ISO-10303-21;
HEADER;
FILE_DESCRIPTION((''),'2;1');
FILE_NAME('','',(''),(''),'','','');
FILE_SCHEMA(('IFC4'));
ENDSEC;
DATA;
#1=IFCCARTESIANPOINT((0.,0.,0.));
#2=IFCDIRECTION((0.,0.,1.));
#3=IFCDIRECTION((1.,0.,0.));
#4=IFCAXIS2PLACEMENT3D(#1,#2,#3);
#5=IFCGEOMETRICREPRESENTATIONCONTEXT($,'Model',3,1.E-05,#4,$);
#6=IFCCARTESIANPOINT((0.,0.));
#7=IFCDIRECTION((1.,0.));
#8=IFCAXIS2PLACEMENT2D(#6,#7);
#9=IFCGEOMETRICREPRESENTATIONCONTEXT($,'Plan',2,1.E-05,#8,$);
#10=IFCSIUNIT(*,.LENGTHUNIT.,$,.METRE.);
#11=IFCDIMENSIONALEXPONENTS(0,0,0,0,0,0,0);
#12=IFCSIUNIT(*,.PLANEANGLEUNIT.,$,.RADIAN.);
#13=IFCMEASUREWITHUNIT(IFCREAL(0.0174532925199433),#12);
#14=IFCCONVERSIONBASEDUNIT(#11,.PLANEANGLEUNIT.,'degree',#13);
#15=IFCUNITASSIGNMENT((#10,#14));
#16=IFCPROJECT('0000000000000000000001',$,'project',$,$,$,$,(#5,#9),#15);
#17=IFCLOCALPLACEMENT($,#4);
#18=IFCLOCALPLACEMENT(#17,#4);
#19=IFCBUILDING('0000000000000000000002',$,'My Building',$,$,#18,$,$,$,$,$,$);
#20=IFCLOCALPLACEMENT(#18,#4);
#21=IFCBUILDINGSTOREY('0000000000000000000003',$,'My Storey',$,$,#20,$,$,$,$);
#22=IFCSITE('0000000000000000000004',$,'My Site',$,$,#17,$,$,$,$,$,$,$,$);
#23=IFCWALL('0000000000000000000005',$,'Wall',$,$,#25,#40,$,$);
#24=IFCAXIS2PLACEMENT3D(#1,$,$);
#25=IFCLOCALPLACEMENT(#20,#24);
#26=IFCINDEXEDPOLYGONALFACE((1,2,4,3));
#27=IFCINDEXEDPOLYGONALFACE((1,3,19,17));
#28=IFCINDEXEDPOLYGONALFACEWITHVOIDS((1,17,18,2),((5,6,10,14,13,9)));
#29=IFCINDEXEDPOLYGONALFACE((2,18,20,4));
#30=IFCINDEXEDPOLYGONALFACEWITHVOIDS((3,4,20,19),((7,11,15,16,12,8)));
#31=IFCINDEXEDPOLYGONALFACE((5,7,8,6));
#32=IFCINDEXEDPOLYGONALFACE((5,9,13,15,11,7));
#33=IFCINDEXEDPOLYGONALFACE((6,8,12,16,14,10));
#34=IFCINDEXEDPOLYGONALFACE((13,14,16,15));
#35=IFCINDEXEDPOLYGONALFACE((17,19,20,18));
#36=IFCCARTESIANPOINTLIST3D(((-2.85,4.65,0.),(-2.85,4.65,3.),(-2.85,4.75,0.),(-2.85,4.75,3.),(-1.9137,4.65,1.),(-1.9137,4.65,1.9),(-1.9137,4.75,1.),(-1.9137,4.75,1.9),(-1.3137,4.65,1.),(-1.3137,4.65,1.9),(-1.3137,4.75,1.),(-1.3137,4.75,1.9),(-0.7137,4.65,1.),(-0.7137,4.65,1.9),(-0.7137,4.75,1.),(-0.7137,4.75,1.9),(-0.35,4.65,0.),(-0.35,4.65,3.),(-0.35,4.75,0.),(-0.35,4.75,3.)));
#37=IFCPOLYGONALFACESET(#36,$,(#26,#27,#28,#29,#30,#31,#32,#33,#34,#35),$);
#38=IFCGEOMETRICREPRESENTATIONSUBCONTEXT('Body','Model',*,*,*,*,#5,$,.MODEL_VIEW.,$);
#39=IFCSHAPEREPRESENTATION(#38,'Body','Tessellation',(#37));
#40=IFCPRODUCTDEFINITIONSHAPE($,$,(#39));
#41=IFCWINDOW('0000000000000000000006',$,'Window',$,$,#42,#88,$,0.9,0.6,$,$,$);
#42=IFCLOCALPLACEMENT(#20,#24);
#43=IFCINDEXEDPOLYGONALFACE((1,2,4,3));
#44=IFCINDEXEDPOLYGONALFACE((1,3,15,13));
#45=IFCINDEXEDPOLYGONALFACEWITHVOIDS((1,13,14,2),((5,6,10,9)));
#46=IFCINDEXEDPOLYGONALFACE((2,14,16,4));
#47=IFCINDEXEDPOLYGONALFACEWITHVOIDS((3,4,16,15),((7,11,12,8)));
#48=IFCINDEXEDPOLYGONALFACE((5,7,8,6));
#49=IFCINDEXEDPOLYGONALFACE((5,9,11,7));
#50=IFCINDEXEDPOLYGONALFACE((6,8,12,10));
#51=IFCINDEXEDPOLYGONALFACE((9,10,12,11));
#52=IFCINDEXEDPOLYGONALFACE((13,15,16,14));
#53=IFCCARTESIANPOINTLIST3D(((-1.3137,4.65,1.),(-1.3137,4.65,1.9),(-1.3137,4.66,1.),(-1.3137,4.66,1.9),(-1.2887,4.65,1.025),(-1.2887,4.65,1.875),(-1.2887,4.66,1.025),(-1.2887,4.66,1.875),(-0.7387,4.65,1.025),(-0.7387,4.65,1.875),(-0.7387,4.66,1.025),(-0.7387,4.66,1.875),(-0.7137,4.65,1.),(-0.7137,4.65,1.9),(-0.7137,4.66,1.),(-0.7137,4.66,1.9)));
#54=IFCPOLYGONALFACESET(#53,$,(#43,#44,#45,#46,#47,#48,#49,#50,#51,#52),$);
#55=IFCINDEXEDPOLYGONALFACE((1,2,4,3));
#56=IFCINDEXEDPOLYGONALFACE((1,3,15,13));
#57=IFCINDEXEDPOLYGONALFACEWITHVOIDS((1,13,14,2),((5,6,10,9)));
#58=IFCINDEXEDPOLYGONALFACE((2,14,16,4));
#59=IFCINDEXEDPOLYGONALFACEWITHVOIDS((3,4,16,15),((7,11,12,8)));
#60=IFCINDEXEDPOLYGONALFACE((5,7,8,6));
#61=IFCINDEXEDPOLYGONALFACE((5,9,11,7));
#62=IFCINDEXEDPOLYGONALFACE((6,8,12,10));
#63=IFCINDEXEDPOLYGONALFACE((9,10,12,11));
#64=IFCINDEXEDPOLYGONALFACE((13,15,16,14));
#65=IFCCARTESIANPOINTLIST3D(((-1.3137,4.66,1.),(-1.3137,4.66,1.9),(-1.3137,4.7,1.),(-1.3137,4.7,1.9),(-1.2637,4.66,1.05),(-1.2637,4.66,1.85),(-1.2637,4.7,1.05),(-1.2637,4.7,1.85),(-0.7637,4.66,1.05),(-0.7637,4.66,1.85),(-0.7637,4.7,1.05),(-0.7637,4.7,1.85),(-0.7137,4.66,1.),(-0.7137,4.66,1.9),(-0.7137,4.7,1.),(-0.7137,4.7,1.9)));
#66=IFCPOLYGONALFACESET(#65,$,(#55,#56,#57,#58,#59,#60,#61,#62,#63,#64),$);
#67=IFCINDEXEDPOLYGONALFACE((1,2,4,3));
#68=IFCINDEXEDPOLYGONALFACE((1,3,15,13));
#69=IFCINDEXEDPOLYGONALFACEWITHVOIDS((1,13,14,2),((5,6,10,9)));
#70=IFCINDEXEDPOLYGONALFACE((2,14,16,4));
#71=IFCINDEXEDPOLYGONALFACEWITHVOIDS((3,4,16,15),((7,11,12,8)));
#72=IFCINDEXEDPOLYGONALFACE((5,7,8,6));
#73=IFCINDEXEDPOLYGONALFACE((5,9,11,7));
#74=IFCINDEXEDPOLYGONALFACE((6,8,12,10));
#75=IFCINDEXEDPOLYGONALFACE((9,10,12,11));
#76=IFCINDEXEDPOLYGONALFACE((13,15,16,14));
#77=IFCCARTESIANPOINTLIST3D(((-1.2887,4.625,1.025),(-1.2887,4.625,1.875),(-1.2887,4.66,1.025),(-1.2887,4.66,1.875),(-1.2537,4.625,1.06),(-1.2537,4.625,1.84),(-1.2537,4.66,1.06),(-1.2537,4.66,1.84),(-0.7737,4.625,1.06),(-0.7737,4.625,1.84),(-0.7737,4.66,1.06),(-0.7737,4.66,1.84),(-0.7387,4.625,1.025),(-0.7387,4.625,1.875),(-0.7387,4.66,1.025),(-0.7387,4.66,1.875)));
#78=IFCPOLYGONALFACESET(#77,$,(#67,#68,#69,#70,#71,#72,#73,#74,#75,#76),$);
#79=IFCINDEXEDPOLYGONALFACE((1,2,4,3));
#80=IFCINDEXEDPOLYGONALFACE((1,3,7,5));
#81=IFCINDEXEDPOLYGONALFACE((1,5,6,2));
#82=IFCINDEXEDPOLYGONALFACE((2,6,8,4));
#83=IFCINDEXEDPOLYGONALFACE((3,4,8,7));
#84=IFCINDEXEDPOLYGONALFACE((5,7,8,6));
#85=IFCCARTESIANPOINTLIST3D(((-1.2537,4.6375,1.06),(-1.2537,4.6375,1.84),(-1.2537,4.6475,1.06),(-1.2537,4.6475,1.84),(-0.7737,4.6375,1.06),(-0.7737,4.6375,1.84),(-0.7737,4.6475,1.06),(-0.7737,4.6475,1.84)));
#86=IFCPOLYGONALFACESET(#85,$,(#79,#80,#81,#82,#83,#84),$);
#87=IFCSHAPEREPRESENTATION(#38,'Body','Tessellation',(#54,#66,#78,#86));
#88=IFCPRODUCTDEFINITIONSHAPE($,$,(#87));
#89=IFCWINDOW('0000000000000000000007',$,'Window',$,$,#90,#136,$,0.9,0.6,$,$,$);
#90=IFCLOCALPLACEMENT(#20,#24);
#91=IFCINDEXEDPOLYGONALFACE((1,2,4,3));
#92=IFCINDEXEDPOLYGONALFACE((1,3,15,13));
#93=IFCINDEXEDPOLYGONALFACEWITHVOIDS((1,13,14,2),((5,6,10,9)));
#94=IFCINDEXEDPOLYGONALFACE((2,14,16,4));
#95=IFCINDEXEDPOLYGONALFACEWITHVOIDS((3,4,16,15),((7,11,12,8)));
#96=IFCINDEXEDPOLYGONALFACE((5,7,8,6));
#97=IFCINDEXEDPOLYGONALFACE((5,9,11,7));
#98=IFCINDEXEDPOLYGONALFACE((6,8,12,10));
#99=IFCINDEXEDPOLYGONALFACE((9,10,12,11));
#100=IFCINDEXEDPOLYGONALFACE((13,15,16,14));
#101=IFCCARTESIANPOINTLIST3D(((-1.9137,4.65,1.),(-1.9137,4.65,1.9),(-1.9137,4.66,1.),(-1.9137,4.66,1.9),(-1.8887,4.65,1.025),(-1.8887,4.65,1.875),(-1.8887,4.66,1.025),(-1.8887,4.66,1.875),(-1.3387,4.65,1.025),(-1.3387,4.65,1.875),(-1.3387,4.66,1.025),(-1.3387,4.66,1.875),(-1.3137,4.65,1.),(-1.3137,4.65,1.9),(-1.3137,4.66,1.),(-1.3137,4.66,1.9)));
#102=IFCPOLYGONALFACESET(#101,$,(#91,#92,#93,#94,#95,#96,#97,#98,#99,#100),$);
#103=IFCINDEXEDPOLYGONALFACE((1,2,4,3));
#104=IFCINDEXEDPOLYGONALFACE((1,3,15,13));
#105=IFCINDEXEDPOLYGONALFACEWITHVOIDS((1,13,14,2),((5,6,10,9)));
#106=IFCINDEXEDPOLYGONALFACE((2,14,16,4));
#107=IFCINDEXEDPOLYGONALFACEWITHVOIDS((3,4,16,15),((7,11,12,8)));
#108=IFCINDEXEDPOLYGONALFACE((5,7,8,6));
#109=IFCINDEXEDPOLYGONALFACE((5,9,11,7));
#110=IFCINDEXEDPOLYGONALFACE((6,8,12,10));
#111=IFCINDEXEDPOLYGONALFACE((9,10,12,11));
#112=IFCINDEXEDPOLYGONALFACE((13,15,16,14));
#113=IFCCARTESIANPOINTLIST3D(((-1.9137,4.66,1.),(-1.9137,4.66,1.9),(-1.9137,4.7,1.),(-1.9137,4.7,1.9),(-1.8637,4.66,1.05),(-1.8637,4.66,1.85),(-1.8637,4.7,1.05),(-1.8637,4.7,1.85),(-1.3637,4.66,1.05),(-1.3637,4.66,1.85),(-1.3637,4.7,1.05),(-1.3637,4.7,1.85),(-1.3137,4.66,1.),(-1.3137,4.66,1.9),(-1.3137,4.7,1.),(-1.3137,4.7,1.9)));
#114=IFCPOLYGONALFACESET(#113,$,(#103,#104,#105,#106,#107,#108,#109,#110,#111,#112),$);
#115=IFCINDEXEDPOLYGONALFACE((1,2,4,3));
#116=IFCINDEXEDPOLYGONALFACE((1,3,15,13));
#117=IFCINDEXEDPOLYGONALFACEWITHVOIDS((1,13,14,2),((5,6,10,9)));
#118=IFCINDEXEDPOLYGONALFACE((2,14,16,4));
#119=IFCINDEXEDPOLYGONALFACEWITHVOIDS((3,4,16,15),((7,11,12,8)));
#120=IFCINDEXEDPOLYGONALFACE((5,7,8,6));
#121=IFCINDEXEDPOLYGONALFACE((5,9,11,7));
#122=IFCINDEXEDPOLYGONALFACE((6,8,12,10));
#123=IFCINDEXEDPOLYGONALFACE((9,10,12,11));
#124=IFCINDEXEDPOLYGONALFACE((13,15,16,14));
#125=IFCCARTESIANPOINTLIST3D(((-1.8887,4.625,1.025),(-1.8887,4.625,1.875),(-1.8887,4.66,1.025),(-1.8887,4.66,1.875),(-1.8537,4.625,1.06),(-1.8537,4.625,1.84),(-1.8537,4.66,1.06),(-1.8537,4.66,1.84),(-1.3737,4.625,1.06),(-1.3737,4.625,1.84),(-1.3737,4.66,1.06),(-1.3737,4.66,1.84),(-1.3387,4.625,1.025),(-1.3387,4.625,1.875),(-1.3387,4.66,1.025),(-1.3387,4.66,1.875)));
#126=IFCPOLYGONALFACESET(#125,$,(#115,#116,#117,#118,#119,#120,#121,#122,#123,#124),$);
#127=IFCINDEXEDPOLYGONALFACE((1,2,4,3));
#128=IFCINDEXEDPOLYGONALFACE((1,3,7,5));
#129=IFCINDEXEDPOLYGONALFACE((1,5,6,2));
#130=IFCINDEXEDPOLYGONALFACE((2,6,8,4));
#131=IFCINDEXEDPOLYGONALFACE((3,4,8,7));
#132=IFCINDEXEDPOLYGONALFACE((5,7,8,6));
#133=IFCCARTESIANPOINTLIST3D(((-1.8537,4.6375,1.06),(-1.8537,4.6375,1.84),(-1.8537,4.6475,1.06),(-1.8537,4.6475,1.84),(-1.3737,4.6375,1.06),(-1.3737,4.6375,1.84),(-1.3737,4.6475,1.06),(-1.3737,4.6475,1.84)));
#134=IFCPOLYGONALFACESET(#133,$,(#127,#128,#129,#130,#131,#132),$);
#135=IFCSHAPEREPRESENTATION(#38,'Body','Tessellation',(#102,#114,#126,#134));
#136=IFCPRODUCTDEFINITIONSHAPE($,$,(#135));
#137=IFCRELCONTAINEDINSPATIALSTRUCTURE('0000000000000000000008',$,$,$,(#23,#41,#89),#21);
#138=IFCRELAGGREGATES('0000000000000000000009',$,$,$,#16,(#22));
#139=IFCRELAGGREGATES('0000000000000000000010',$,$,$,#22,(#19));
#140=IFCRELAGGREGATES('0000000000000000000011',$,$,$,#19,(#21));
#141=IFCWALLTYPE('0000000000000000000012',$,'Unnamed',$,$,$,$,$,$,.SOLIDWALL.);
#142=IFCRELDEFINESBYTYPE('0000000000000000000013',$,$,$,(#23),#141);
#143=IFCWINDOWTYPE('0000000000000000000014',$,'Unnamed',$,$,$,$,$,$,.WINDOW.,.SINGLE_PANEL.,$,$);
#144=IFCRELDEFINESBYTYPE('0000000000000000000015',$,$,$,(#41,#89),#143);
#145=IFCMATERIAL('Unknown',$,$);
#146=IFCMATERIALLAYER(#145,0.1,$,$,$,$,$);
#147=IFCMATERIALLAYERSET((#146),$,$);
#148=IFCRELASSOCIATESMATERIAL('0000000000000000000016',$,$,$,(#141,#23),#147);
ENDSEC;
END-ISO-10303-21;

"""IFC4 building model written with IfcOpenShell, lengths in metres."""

from ifc_helpers import new_model, entity, si_unit, converted_unit, frame, origin_with_axes, origin_2d_with_axis, place, context, subcontext, project, spatial, line, indexed_curve, outline, extrude, shape, source, transform, mapped, material, layer, layer_set, layer_usage, type_object, type_shapes, element, fill, save


model = new_model("IFC4")

# Units and contexts
model_context = context("Model", 3, precision=1e-05, world=origin_with_axes())
plan_context = context("Plan", 2, precision=1e-05, world=origin_2d_with_axis())
body_context_1 = subcontext(model_context, "Body", "Model", "MODEL_VIEW")
body_context_2 = subcontext(plan_context, "Body", "Plan", "PLAN_VIEW")
ifc_project = project(units=[si_unit("LENGTHUNIT", "METRE"), converted_unit("PLANEANGLEUNIT", "degree", entity("IfcReal", 0.0174532925199433), si_unit("PLANEANGLEUNIT", "RADIAN"), dimensions=[0, 0, 0, 0, 0, 0, 0])], contexts=[model_context, plan_context])

# Site, building, storey
site_placement = place(None, origin_with_axes())
site = spatial("IfcSite", under=ifc_project, at=site_placement, Name="My Site")
building_placement = place(site_placement, origin_with_axes())
building = spatial("IfcBuilding", under=site, at=building_placement, Name="My Building")
storey_placement = place(building_placement, origin_with_axes())
storey = spatial("IfcBuildingStorey", under=building, at=storey_placement, Name="My Storey")

# Shared definitions
ifc_material = material(Name="Unknown")

# Shared definitions
ifc_layer_1 = layer(ifc_material, 0.1)
ifc_layer_set_1 = layer_set([ifc_layer_1])
wall_type = type_object("IfcWallType", Name="Unnamed", PredefinedType="SOLIDWALL", material=ifc_layer_set_1)
shared_shape_1 = source(origin_with_axes(), body_context_1, "Body", "SweptSolid", [
    extrude(outline(indexed_curve([(0.0, 0.0), (0.6, 0.0), (0.6, 0.9), (0.0, 0.9)], segments=[line(1, 2, 3, 4, 1)])), frame((0.0, -0.6, 0.0), z_axis=(0.0, -1.0, 0.0), x_axis=(1.0, 0.0, 0.0)), (0.0, 0.0, -1.0), 1.2),
])
window_type = type_object("IfcWindowType", Name="Unnamed", PartitioningType="SINGLE_PANEL", PredefinedType="WINDOW")
shared_shape_2 = source(origin_with_axes(), body_context_1, "Body", "SweptSolid", [
    extrude(outline(indexed_curve([(0.0, 0.0), (0.6, 0.0), (0.6, 0.9), (0.0, 0.9)], segments=[line(1, 2, 3, 4, 1)]), holes=[indexed_curve([(0.025, 0.025), (0.575, 0.025), (0.575, 0.875), (0.025, 0.875)], segments=[line(1, 2, 3, 4, 1)])]), frame((0.0, 0.09, 0.0), z_axis=(0.0, -1.0, 0.0), x_axis=(1.0, 0.0, 0.0)), (0.0, 0.0, -1.0), 0.01),
    extrude(outline(indexed_curve([(0.0, 0.0), (0.6, 0.0), (0.6, 0.9), (0.0, 0.9)], segments=[line(1, 2, 3, 4, 1)]), holes=[indexed_curve([(0.05, 0.05), (0.55, 0.05), (0.55, 0.85), (0.05, 0.85)], segments=[line(1, 2, 3, 4, 1)])]), frame((0.0, 0.05, 0.0), z_axis=(0.0, -1.0, 0.0), x_axis=(1.0, 0.0, 0.0)), (0.0, 0.0, -1.0), 0.04),
    extrude(outline(indexed_curve([(0.0, 0.0), (0.55, 0.0), (0.55, 0.85), (0.0, 0.85)], segments=[line(1, 2, 3, 4, 1)]), holes=[indexed_curve([(0.035, 0.035), (0.515, 0.035), (0.515, 0.815), (0.035, 0.815)], segments=[line(1, 2, 3, 4, 1)])]), frame((0.025, 0.09, 0.025), z_axis=(0.0, -1.0, 0.0), x_axis=(1.0, 0.0, 0.0)), (0.0, 0.0, -1.0), 0.035),
    extrude(outline(indexed_curve([(0.035, 0.035), (0.515, 0.035), (0.515, 0.815), (0.035, 0.815)], segments=[line(1, 2, 3, 4, 1)])), frame((0.025, 0.1025, 0.025), z_axis=(0.0, -1.0, 0.0), x_axis=(1.0, 0.0, 0.0)), (0.0, 0.0, -1.0), 0.01),
])
shared_shape_3 = source(origin_with_axes(), body_context_2, "Body", "Curve2D", [
    entity("IfcIndexedPolyCurve", entity("IfcCartesianPointList2D", [[0.05, 0.05], [0.55, 0.05]])),
    entity("IfcIndexedPolyCurve", entity("IfcCartesianPointList2D", [[0.0, 0.1], [0.025, 0.1], [0.025, 0.09], [0.05, 0.09], [0.05, 0.05], [0.0, 0.05]]), [entity("IfcLineIndex", [1, 2, 3, 4, 5, 6, 1])]),
    entity("IfcIndexedPolyCurve", entity("IfcCartesianPointList2D", [[0.6, 0.1], [0.575, 0.1], [0.575, 0.09], [0.55, 0.09], [0.55, 0.05], [0.6, 0.05]]), [entity("IfcLineIndex", [1, 2, 3, 4, 5, 6, 1])]),
    entity("IfcIndexedPolyCurve", entity("IfcCartesianPointList2D", [[0.025, 0.09], [0.06, 0.09], [0.06, 0.125], [0.025, 0.125]]), [entity("IfcLineIndex", [1, 2, 3, 4, 1])]),
    entity("IfcIndexedPolyCurve", entity("IfcCartesianPointList2D", [[0.575, 0.09], [0.54, 0.09], [0.54, 0.125], [0.575, 0.125]]), [entity("IfcLineIndex", [1, 2, 3, 4, 1])]),
    entity("IfcIndexedPolyCurve", entity("IfcCartesianPointList2D", [[0.06, 0.09], [0.54, 0.09]])),
    entity("IfcIndexedPolyCurve", entity("IfcCartesianPointList2D", [[0.06, 0.125], [0.54, 0.125]])),
    entity("IfcIndexedPolyCurve", entity("IfcCartesianPointList2D", [[0.06, 0.1075], [0.54, 0.1075]])),
])
type_shapes(window_type, [shared_shape_2, shared_shape_3])

# Wall, openings, windows
ifc_layer_usage_1 = layer_usage(ifc_layer_set_1, "AXIS2", "POSITIVE", 0.0)
wall_1_placement = place(storey_placement, frame((-0.35, 4.75, 0.0), z_axis=(0.0, 0.0, 1.0), x_axis=(-1.0, 0.0, 0.0)))
wall_1 = element("IfcWall", 1, at=wall_1_placement, inside=storey, type_object=wall_type, material=ifc_layer_usage_1, Name="Wall", context=body_context_1, shape_type="SweptSolid", body=[
    extrude(outline(indexed_curve([(0.0, 0.0), (0.0, 0.1), (2.5, 0.1), (2.5, 0.0)], segments=[line(1, 2, 3, 4, 1)])), origin_with_axes(), (0.0, 0.0, 1.0), 3.0),
])
opening_1_placement = place(wall_1_placement, frame((0.3637, 0.0, 1.0), z_axis=(0.0, 0.0, 1.0), x_axis=(1.0, 0.0, 0.0)))
opening_1 = element("IfcOpeningElement", 2, at=opening_1_placement, cuts=wall_1, PredefinedType="OPENING", context=body_context_1, shape_type="MappedRepresentation", body=[
    mapped(shared_shape_1, transform((0.0, 0.0, 0.0), x_axis=(1.0, 0.0, 0.0), y_axis=(0.0, 1.0, 0.0), z_axis=(0.0, 0.0, 1.0), scale=1.0)),
])
opening_2_placement = place(wall_1_placement, frame((0.9637, 0.0, 1.0), z_axis=(0.0, 0.0, 1.0), x_axis=(1.0, 0.0, 0.0)))
opening_2 = element("IfcOpeningElement", 3, at=opening_2_placement, cuts=wall_1, PredefinedType="OPENING", context=body_context_1, shape_type="MappedRepresentation", body=[
    mapped(shared_shape_1, transform((0.0, 0.0, 0.0), x_axis=(1.0, 0.0, 0.0), y_axis=(0.0, 1.0, 0.0), z_axis=(0.0, 0.0, 1.0), scale=1.0)),
])
window_1_placement = place(opening_1_placement, frame((0.0, 0.0, 0.0), z_axis=(0.0, 0.0, 1.0), x_axis=(1.0, 0.0, 0.0)))
window_1 = element("IfcWindow", 4, at=window_1_placement, inside=storey, type_object=window_type, Name="Window", OverallHeight=0.9, OverallWidth=0.6, shapes=[
    shape(body_context_1, "Body", "MappedRepresentation", [mapped(shared_shape_2, transform((0.0, 0.0, 0.0), x_axis=(1.0, 0.0, 0.0), y_axis=(0.0, 1.0, 0.0), z_axis=(0.0, 0.0, 1.0), scale=1.0))]),
    shape(body_context_2, "Body", "MappedRepresentation", [mapped(shared_shape_3, transform((0.0, 0.0, 0.0), x_axis=(1.0, 0.0, 0.0), y_axis=(0.0, 1.0, 0.0), z_axis=(0.0, 0.0, 1.0), scale=1.0))]),
])
fill(opening_1, window_1)
window_2_placement = place(opening_2_placement, frame((0.0, 0.0, 0.0), z_axis=(0.0, 0.0, 1.0), x_axis=(1.0, 0.0, 0.0)))
window_2 = element("IfcWindow", 5, at=window_2_placement, inside=storey, type_object=window_type, Name="Window", OverallHeight=0.9, OverallWidth=0.6, shapes=[
    shape(body_context_1, "Body", "MappedRepresentation", [mapped(shared_shape_2, transform((0.0, 0.0, 0.0), x_axis=(1.0, 0.0, 0.0), y_axis=(0.0, 1.0, 0.0), z_axis=(0.0, 0.0, 1.0), scale=1.0))]),
    shape(body_context_2, "Body", "MappedRepresentation", [mapped(shared_shape_3, transform((0.0, 0.0, 0.0), x_axis=(1.0, 0.0, 0.0), y_axis=(0.0, 1.0, 0.0), z_axis=(0.0, 0.0, 1.0), scale=1.0))]),
])
fill(opening_2, window_2)

save(model, "model.ifc")
